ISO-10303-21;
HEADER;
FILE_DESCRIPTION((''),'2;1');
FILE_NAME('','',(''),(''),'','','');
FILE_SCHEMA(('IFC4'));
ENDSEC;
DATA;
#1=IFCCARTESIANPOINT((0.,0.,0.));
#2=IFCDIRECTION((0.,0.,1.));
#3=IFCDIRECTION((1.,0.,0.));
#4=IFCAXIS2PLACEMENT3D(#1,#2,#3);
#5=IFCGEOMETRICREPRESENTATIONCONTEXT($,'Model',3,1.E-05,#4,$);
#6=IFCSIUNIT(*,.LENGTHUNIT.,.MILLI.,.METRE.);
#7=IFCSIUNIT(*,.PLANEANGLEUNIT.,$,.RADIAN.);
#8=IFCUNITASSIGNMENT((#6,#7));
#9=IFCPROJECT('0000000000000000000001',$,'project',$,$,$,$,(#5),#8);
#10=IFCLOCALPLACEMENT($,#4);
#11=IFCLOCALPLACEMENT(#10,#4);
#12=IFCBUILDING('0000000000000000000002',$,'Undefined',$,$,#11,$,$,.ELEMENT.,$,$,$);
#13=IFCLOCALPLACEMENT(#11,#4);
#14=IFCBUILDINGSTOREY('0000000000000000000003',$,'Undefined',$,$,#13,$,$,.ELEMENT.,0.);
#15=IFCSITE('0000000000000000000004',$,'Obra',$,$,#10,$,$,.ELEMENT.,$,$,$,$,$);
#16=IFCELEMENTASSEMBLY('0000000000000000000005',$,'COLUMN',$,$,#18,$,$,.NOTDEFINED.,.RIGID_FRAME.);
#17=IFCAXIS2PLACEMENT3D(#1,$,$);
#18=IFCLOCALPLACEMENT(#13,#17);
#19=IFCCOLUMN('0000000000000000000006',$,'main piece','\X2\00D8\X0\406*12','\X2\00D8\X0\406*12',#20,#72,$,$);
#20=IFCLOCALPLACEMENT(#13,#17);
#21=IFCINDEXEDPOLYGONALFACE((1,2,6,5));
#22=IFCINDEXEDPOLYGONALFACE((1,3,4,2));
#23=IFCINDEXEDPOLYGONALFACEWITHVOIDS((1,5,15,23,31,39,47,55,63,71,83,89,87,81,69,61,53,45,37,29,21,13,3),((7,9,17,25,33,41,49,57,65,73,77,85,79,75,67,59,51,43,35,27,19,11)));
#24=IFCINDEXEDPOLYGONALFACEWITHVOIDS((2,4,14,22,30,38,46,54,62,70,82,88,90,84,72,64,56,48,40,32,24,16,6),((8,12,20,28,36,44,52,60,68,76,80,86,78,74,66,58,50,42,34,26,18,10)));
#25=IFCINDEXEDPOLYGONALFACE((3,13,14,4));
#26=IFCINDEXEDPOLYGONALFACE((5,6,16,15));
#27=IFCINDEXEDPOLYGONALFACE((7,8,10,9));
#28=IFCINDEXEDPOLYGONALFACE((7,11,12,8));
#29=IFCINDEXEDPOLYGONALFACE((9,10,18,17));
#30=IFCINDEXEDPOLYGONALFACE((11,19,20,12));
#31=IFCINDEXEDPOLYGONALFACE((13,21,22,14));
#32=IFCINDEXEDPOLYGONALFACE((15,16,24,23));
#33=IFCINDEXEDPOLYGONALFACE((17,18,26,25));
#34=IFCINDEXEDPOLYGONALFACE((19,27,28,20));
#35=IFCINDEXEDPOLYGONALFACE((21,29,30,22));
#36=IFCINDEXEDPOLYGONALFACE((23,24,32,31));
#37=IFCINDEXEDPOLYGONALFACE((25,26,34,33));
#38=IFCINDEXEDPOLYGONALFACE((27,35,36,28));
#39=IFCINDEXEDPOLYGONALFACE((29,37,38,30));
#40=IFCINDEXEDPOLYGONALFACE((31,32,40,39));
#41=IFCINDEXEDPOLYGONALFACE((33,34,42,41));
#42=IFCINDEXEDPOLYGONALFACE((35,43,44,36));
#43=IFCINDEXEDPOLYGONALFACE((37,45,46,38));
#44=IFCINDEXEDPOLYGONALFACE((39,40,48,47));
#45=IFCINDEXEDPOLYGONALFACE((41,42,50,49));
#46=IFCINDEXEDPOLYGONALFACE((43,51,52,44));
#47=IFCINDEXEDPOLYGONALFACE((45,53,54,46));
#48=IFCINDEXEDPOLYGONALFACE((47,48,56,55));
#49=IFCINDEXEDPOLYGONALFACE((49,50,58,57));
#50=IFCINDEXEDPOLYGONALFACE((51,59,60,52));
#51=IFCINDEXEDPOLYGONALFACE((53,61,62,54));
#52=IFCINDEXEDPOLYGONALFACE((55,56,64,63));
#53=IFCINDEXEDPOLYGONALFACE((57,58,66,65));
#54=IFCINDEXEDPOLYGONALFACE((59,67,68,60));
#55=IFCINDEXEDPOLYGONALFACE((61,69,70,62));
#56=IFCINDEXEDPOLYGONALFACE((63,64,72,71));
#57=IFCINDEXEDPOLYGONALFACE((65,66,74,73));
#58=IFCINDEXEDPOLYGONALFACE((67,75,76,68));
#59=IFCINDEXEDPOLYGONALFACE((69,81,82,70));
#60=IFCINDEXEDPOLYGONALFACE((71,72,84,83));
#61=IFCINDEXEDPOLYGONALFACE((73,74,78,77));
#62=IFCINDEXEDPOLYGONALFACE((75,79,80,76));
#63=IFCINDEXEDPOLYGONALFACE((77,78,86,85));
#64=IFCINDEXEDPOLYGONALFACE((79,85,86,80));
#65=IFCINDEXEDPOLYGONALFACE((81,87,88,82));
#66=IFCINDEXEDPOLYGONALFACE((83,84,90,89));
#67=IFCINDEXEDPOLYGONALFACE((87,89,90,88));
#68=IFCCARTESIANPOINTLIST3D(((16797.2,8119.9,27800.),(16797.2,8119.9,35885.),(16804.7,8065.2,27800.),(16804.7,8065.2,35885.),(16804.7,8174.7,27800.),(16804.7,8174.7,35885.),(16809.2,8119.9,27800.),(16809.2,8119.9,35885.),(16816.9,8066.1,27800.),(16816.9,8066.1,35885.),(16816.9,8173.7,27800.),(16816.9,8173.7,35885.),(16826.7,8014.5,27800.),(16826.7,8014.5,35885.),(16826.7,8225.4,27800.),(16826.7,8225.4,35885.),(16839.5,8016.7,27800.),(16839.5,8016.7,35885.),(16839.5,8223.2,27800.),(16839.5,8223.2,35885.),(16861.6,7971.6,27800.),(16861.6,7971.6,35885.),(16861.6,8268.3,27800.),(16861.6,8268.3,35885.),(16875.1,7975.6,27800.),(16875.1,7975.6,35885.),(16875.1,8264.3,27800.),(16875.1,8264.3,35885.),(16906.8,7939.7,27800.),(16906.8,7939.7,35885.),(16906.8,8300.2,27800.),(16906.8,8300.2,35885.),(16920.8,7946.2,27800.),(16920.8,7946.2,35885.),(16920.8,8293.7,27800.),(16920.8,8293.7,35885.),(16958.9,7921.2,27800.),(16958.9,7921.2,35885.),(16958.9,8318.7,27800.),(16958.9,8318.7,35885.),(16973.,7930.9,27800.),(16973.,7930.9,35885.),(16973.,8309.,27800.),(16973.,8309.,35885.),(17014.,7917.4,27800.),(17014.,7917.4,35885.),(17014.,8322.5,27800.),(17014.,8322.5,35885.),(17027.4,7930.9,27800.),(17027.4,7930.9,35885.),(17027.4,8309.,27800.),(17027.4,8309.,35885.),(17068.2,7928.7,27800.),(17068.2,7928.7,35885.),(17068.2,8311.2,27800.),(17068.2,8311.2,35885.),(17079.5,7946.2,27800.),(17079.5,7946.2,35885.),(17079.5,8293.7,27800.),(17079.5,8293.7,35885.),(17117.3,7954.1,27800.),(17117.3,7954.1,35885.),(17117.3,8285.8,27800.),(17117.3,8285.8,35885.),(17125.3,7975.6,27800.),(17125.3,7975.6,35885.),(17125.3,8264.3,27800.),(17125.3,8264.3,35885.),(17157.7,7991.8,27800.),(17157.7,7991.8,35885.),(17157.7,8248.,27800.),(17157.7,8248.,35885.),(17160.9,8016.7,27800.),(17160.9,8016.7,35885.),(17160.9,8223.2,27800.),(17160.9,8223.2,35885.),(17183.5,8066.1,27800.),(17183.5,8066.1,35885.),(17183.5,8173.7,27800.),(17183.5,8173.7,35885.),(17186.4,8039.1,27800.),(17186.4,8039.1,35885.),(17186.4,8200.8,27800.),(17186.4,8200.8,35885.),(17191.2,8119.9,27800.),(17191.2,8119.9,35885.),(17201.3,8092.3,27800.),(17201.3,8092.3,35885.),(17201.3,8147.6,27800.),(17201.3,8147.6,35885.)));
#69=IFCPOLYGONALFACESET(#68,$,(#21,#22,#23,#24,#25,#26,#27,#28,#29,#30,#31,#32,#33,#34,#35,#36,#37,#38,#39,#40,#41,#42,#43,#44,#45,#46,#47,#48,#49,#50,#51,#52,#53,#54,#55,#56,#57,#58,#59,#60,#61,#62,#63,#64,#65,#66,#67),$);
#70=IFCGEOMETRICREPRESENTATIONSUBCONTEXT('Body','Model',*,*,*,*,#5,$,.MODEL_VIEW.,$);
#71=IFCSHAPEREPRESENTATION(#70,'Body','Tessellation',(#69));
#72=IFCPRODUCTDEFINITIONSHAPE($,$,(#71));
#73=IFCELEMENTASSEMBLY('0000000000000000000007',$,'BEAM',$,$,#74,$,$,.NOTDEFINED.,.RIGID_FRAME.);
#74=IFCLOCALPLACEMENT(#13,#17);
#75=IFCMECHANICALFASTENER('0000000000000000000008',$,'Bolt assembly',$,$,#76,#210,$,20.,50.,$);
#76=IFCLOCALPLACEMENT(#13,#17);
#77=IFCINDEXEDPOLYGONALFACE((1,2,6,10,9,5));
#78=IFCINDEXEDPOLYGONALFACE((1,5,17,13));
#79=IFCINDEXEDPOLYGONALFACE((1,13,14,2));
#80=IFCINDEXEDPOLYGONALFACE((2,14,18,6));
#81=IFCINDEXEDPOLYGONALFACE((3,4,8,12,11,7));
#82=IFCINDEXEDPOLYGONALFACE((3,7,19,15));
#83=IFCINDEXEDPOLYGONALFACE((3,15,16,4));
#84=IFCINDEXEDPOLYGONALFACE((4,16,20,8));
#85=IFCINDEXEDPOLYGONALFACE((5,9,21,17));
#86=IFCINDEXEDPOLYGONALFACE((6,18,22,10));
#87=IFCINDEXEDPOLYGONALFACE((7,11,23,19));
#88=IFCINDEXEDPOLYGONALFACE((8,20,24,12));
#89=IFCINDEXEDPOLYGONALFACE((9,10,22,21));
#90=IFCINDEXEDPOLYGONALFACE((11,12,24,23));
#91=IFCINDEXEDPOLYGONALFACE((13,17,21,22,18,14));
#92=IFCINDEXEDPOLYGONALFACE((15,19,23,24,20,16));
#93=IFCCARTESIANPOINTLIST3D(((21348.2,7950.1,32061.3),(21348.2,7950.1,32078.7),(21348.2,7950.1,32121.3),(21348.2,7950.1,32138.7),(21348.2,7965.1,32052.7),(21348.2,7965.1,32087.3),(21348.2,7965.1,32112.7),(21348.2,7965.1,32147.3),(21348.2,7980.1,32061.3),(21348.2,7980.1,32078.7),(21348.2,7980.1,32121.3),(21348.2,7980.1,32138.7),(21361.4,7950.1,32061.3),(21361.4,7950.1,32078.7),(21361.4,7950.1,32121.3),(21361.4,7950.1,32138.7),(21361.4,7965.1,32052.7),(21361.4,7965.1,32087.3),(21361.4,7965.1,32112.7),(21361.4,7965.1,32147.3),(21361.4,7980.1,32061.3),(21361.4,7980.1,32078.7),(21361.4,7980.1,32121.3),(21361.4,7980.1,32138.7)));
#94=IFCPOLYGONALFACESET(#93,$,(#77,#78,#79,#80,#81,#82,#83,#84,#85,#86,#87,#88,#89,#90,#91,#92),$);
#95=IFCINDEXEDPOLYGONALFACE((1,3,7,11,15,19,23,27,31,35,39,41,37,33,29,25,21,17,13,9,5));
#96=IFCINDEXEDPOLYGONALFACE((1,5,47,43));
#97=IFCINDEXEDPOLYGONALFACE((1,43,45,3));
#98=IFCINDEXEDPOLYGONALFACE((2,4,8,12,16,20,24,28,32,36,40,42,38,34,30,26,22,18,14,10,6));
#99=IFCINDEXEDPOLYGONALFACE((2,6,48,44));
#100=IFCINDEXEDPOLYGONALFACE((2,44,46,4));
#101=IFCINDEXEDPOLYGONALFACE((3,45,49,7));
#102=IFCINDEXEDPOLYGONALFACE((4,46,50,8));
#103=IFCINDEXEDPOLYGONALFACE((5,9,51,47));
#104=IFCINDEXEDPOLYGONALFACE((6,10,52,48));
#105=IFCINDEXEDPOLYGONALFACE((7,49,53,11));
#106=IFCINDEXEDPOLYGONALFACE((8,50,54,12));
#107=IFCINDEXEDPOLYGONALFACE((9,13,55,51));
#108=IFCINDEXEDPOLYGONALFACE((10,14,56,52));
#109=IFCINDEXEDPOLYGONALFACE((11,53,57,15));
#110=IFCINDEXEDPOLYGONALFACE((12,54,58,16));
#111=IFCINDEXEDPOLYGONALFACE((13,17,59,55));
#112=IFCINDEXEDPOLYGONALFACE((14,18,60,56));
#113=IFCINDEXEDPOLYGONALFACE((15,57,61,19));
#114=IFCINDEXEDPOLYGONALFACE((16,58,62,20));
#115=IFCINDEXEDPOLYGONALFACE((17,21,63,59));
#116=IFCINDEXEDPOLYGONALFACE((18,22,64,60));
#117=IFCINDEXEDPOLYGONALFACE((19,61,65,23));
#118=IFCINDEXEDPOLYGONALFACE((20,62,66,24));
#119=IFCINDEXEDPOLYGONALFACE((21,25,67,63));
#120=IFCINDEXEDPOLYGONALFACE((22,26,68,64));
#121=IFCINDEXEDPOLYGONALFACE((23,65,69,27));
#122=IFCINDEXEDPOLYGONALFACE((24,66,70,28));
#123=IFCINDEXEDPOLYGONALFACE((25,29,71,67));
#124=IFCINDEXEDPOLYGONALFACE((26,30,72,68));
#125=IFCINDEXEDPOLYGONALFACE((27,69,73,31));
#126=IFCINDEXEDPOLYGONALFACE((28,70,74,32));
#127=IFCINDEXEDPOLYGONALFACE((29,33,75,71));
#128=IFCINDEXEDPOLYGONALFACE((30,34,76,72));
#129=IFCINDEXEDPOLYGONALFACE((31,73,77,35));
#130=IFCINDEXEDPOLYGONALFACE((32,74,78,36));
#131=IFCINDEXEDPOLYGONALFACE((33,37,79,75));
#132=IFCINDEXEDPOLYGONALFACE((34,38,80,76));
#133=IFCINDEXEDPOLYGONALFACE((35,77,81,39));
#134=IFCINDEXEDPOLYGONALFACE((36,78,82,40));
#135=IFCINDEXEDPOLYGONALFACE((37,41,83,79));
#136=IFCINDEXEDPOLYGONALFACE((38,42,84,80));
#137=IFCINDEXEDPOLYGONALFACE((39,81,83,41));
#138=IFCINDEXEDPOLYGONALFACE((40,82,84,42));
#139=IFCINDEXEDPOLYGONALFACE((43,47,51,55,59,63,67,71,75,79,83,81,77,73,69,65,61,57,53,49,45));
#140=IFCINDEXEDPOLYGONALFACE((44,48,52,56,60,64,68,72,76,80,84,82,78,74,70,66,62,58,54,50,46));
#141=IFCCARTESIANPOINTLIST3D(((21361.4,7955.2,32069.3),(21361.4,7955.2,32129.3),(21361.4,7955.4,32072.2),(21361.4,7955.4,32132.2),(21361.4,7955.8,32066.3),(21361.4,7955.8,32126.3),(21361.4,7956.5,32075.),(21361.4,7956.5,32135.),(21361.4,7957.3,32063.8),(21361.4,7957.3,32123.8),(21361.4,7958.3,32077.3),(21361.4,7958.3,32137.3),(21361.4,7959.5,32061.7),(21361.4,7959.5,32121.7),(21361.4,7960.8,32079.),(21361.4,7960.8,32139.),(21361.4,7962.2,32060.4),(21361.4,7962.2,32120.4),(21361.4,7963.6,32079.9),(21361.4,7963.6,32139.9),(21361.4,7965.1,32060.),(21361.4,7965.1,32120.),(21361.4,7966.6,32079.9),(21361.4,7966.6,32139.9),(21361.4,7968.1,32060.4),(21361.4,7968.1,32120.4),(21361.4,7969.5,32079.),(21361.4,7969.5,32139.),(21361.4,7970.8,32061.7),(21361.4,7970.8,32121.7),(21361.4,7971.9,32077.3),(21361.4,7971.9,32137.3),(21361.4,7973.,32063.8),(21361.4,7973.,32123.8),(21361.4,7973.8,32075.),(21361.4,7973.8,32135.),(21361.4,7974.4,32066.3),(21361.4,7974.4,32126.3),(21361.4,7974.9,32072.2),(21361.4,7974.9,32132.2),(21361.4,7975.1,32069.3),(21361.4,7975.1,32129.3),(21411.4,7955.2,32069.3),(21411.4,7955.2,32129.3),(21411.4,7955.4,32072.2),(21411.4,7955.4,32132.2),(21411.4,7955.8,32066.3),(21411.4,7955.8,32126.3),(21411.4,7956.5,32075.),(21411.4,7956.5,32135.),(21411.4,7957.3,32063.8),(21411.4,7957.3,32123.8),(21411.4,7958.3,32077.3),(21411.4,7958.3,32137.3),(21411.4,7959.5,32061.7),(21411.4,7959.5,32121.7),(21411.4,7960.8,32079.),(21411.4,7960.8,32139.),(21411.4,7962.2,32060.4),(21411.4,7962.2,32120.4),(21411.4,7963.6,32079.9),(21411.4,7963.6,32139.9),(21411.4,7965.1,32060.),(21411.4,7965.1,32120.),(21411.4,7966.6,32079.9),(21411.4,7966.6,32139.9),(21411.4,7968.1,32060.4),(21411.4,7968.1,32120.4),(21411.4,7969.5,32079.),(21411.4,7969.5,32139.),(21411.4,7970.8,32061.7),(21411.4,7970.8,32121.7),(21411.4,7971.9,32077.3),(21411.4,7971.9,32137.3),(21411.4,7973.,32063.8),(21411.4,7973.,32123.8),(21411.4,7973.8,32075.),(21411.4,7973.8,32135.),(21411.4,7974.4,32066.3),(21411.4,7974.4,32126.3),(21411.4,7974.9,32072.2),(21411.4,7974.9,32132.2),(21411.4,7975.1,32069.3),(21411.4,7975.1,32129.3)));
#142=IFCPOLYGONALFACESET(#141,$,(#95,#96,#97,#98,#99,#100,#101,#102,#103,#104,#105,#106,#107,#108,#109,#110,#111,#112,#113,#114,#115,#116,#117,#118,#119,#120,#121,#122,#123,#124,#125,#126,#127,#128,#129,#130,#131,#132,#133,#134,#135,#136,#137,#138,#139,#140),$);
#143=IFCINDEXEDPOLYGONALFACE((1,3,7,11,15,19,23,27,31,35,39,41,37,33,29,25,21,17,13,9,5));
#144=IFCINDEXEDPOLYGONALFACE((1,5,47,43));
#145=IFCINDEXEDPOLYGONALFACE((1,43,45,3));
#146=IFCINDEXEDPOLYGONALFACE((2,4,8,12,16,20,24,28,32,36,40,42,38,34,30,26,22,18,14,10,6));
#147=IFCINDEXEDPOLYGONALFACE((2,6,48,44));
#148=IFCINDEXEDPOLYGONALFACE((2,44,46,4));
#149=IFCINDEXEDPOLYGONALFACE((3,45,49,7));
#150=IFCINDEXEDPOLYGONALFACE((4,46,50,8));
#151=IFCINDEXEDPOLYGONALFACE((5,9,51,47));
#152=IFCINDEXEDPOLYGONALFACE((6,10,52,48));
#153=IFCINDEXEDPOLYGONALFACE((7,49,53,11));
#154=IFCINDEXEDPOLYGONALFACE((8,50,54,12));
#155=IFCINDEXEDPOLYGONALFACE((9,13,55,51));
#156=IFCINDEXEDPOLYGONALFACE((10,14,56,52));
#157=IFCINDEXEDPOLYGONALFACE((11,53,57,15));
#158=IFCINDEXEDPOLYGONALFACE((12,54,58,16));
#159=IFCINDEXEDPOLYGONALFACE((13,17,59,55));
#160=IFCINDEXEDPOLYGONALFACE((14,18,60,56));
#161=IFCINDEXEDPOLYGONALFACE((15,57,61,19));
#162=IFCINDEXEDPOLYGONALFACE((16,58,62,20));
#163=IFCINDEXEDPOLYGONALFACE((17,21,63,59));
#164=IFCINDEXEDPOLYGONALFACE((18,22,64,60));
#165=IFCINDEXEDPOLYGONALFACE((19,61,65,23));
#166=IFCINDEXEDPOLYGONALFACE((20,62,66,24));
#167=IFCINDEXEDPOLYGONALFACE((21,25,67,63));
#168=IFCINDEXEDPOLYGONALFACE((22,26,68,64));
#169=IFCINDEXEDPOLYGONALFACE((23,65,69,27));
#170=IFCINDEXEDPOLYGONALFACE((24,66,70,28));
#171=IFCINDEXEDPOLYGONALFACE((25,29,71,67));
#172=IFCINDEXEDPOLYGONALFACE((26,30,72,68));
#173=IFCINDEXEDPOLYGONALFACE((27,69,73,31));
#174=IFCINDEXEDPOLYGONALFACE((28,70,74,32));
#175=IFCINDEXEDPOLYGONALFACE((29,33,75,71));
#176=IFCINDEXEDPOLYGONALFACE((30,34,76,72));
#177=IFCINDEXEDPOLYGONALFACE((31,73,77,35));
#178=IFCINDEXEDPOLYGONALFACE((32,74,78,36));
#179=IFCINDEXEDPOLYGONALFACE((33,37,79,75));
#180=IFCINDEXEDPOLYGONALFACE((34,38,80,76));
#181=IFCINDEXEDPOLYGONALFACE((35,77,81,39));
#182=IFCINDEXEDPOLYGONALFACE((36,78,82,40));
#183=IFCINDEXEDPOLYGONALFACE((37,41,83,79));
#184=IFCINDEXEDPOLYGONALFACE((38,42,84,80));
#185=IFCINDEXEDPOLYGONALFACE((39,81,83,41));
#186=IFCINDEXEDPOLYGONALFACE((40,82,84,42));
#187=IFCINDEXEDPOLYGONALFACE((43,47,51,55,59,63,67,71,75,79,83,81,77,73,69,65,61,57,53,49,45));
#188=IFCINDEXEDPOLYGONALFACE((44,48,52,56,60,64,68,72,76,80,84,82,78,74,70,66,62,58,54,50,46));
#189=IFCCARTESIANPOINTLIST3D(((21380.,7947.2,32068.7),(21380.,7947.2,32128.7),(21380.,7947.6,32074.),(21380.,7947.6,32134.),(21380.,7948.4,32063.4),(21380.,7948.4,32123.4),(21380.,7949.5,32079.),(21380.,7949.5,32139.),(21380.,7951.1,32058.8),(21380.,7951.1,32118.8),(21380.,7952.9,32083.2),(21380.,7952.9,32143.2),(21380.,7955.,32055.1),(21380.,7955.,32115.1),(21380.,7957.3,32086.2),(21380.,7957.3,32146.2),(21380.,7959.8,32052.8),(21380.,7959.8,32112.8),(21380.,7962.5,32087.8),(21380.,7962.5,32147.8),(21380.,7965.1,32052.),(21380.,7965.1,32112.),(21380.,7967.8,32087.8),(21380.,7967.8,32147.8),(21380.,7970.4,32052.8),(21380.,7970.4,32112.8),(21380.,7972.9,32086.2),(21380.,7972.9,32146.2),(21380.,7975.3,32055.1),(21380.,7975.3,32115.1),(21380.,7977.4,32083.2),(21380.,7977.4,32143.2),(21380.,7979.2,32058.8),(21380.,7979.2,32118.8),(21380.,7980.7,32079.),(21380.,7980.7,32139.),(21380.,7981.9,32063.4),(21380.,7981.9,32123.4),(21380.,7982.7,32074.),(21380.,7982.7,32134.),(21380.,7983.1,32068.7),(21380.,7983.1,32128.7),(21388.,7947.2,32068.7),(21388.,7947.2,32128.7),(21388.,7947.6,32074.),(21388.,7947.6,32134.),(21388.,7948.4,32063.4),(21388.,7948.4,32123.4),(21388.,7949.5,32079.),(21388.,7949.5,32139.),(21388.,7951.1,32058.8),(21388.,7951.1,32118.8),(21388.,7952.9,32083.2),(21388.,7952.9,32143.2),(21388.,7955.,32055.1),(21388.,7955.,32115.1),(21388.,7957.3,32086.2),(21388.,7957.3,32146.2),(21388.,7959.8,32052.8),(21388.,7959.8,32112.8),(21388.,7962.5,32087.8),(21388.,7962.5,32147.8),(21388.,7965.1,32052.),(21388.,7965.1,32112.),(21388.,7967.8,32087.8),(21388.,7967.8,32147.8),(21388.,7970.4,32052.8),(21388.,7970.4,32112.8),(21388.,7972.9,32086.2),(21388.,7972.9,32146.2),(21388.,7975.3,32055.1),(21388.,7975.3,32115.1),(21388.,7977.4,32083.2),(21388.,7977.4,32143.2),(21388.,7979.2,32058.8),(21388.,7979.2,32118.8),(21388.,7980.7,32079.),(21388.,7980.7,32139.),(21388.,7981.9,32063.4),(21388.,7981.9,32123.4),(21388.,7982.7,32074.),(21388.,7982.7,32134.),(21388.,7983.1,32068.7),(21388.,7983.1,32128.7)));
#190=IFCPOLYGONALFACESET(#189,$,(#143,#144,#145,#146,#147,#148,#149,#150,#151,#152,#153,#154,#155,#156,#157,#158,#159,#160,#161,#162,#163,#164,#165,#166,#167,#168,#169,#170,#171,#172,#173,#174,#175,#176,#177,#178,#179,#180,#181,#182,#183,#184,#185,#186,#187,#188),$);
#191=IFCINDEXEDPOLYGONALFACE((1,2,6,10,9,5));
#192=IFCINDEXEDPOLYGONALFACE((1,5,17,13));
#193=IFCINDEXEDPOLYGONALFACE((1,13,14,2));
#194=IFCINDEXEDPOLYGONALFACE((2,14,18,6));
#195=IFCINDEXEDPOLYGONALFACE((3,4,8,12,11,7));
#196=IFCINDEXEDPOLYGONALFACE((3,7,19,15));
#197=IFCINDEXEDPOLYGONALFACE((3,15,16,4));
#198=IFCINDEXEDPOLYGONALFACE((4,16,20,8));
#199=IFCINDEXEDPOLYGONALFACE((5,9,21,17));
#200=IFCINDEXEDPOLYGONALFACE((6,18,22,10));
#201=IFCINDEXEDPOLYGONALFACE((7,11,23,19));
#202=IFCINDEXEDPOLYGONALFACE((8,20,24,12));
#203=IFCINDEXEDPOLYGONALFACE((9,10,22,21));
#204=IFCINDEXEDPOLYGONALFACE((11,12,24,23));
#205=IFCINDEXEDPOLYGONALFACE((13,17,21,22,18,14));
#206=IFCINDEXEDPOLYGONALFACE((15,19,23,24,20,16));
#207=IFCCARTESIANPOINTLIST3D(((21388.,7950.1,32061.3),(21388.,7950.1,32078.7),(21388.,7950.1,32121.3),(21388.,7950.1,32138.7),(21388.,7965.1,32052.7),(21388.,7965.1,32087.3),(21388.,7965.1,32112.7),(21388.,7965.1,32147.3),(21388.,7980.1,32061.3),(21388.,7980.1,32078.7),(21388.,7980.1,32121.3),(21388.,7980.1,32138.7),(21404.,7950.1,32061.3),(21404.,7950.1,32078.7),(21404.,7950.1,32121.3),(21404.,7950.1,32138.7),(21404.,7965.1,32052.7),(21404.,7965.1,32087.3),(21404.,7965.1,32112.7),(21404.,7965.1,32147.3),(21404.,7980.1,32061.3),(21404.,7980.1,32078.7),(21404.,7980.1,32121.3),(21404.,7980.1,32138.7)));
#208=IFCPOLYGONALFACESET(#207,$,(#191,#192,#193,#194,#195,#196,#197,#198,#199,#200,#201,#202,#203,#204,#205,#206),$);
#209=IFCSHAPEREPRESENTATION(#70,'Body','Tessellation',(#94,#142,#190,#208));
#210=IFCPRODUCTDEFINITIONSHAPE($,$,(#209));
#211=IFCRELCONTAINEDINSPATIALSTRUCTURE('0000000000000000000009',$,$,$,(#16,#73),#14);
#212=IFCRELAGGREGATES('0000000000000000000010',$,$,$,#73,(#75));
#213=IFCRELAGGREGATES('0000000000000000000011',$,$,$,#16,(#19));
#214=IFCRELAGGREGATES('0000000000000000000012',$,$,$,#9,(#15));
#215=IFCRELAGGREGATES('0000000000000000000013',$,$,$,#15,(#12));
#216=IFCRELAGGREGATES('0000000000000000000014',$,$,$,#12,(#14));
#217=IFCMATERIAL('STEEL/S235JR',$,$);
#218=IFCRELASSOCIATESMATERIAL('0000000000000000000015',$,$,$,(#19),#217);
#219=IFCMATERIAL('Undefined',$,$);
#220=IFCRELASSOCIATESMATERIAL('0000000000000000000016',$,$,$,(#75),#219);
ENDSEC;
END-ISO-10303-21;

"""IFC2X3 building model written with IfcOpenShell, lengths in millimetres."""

from ifc_helpers import new_model, si_unit, frame, origin_with_axes, origin_2d_with_axis, place, context, subcontext, project, spatial, polyline, circle, hollow_circle, outline, extrude, clip, halfspace, source, transform, mapped, material, element, aggregate, save


model = new_model("IFC2X3")

# Units and contexts
model_context = context("Model", 3, precision=1e-05, world=origin_with_axes())
body_context = subcontext(model_context, "Body", "Model", "MODEL_VIEW")
ifc_project = project(units=[si_unit("LENGTHUNIT", "METRE", prefix="MILLI"), si_unit("PLANEANGLEUNIT", "RADIAN")], contexts=[model_context])

# Site, building, storey
site_placement = place(None, origin_with_axes())
site = spatial("IfcSite", under=ifc_project, at=site_placement, Name="Obra", CompositionType="ELEMENT")
building_placement = place(site_placement, origin_with_axes())
building = spatial("IfcBuilding", under=site, at=building_placement, Name="Undefined", CompositionType="ELEMENT")
storey_placement = place(building_placement, origin_with_axes())
storey = spatial("IfcBuildingStorey", under=building, at=storey_placement, Name="Undefined", CompositionType="ELEMENT", Elevation=0.0)

# Element assembly, column
assembly_1_placement = place(storey_placement, origin_with_axes())
assembly_1 = element("IfcElementAssembly", 1, at=assembly_1_placement, inside=storey, Name="COLUMN", AssemblyPlace="NOTDEFINED", PredefinedType="RIGID_FRAME")
ifc_material_1 = material(Name="STEEL/S235JR")
column_placement = place(assembly_1_placement, frame((17000.2, 8119.9, 27800.0), z_axis=(0.0, 0.0, 1.0), x_axis=(0.0, 1.0, 0.0)))
column = element("IfcColumn", 2, at=column_placement, material=ifc_material_1, Name="main piece", Description="Ø406*12", ObjectType="Ø406*12", context=body_context, shape_type="Clipping", body=[
    clip(extrude(hollow_circle(Radius=203.0, WallThickness=12.0, at=origin_2d_with_axis()), frame((0.0, 0.0, 8085.0), z_axis=(0.0, 0.0, -1.0), x_axis=(0.0, 1.0, 0.0)), (0.0, 0.0, 1.0), 8085.0), halfspace(frame((-203.0, 0.0, 8085.0), z_axis=(0.0, 0.0, -1.0), x_axis=(0.0, -1.0, 0.0)), True)),
])

# Shared definitions
ifc_material_2 = material(Name="Undefined")

# Element assembly, mechanical fastener
assembly_2_placement = place(storey_placement, origin_with_axes())
assembly_2 = element("IfcElementAssembly", 3, at=assembly_2_placement, inside=storey, Name="BEAM", AssemblyPlace="NOTDEFINED", PredefinedType="RIGID_FRAME")
shared_shape_1 = source(origin_with_axes(), body_context, "Body", "SweptSolid", [
    extrude(outline(polyline([(17.3, 0.0), (8.7, 15.0), (-8.7, 15.0), (-17.3, 0.0), (-8.7, -15.0), (8.7, -15.0), (17.3, 0.0)])), frame((0.0, -27.5, 0.0), z_axis=(0.0, 1.0, 0.0), x_axis=(1.0, 0.0, 0.0)), (0.0, 0.0, 1.0), 13.2),
    extrude(circle(Radius=10.0, at=origin_2d_with_axis()), frame((0.0, -14.3, 0.0), z_axis=(0.0, 1.0, 0.0), x_axis=(1.0, 0.0, 0.0)), (0.0, 0.0, 1.0), 50.0),
    extrude(circle(Radius=18.0, at=origin_2d_with_axis()), frame((0.0, 4.3, 0.0), z_axis=(0.0, 1.0, 0.0), x_axis=(1.0, 0.0, 0.0)), (0.0, 0.0, 1.0), 8.0),
    extrude(outline(polyline([(17.3, 0.0), (8.7, 15.0), (-8.7, 15.0), (-17.3, 0.0), (-8.7, -15.0), (8.7, -15.0), (17.3, 0.0)])), frame((0.0, 12.3, 0.0), z_axis=(0.0, 1.0, 0.0), x_axis=(1.0, 0.0, 0.0)), (0.0, 0.0, 1.0), 16.0),
])
mechanical_fastener_1_placement = place(assembly_2_placement, frame((21375.7, 8005.1, 32170.0), z_axis=(0.0, -1.0, 0.0), x_axis=(0.0, 0.0, -1.0)))
mechanical_fastener_1 = element("IfcMechanicalFastener", 4, at=mechanical_fastener_1_placement, material=ifc_material_2, Name="Bolt assembly", NominalDiameter=20.0, NominalLength=50.0, context=body_context, shape_type="MappedRepresentation", body=[
    mapped(shared_shape_1, transform((40.0, 0.0, 40.0))),
    mapped(shared_shape_1, transform((100.0, 0.0, 40.0))),
])
aggregate(assembly_2, [mechanical_fastener_1])

aggregate(assembly_1, [column])

save(model, "model.ifc")
